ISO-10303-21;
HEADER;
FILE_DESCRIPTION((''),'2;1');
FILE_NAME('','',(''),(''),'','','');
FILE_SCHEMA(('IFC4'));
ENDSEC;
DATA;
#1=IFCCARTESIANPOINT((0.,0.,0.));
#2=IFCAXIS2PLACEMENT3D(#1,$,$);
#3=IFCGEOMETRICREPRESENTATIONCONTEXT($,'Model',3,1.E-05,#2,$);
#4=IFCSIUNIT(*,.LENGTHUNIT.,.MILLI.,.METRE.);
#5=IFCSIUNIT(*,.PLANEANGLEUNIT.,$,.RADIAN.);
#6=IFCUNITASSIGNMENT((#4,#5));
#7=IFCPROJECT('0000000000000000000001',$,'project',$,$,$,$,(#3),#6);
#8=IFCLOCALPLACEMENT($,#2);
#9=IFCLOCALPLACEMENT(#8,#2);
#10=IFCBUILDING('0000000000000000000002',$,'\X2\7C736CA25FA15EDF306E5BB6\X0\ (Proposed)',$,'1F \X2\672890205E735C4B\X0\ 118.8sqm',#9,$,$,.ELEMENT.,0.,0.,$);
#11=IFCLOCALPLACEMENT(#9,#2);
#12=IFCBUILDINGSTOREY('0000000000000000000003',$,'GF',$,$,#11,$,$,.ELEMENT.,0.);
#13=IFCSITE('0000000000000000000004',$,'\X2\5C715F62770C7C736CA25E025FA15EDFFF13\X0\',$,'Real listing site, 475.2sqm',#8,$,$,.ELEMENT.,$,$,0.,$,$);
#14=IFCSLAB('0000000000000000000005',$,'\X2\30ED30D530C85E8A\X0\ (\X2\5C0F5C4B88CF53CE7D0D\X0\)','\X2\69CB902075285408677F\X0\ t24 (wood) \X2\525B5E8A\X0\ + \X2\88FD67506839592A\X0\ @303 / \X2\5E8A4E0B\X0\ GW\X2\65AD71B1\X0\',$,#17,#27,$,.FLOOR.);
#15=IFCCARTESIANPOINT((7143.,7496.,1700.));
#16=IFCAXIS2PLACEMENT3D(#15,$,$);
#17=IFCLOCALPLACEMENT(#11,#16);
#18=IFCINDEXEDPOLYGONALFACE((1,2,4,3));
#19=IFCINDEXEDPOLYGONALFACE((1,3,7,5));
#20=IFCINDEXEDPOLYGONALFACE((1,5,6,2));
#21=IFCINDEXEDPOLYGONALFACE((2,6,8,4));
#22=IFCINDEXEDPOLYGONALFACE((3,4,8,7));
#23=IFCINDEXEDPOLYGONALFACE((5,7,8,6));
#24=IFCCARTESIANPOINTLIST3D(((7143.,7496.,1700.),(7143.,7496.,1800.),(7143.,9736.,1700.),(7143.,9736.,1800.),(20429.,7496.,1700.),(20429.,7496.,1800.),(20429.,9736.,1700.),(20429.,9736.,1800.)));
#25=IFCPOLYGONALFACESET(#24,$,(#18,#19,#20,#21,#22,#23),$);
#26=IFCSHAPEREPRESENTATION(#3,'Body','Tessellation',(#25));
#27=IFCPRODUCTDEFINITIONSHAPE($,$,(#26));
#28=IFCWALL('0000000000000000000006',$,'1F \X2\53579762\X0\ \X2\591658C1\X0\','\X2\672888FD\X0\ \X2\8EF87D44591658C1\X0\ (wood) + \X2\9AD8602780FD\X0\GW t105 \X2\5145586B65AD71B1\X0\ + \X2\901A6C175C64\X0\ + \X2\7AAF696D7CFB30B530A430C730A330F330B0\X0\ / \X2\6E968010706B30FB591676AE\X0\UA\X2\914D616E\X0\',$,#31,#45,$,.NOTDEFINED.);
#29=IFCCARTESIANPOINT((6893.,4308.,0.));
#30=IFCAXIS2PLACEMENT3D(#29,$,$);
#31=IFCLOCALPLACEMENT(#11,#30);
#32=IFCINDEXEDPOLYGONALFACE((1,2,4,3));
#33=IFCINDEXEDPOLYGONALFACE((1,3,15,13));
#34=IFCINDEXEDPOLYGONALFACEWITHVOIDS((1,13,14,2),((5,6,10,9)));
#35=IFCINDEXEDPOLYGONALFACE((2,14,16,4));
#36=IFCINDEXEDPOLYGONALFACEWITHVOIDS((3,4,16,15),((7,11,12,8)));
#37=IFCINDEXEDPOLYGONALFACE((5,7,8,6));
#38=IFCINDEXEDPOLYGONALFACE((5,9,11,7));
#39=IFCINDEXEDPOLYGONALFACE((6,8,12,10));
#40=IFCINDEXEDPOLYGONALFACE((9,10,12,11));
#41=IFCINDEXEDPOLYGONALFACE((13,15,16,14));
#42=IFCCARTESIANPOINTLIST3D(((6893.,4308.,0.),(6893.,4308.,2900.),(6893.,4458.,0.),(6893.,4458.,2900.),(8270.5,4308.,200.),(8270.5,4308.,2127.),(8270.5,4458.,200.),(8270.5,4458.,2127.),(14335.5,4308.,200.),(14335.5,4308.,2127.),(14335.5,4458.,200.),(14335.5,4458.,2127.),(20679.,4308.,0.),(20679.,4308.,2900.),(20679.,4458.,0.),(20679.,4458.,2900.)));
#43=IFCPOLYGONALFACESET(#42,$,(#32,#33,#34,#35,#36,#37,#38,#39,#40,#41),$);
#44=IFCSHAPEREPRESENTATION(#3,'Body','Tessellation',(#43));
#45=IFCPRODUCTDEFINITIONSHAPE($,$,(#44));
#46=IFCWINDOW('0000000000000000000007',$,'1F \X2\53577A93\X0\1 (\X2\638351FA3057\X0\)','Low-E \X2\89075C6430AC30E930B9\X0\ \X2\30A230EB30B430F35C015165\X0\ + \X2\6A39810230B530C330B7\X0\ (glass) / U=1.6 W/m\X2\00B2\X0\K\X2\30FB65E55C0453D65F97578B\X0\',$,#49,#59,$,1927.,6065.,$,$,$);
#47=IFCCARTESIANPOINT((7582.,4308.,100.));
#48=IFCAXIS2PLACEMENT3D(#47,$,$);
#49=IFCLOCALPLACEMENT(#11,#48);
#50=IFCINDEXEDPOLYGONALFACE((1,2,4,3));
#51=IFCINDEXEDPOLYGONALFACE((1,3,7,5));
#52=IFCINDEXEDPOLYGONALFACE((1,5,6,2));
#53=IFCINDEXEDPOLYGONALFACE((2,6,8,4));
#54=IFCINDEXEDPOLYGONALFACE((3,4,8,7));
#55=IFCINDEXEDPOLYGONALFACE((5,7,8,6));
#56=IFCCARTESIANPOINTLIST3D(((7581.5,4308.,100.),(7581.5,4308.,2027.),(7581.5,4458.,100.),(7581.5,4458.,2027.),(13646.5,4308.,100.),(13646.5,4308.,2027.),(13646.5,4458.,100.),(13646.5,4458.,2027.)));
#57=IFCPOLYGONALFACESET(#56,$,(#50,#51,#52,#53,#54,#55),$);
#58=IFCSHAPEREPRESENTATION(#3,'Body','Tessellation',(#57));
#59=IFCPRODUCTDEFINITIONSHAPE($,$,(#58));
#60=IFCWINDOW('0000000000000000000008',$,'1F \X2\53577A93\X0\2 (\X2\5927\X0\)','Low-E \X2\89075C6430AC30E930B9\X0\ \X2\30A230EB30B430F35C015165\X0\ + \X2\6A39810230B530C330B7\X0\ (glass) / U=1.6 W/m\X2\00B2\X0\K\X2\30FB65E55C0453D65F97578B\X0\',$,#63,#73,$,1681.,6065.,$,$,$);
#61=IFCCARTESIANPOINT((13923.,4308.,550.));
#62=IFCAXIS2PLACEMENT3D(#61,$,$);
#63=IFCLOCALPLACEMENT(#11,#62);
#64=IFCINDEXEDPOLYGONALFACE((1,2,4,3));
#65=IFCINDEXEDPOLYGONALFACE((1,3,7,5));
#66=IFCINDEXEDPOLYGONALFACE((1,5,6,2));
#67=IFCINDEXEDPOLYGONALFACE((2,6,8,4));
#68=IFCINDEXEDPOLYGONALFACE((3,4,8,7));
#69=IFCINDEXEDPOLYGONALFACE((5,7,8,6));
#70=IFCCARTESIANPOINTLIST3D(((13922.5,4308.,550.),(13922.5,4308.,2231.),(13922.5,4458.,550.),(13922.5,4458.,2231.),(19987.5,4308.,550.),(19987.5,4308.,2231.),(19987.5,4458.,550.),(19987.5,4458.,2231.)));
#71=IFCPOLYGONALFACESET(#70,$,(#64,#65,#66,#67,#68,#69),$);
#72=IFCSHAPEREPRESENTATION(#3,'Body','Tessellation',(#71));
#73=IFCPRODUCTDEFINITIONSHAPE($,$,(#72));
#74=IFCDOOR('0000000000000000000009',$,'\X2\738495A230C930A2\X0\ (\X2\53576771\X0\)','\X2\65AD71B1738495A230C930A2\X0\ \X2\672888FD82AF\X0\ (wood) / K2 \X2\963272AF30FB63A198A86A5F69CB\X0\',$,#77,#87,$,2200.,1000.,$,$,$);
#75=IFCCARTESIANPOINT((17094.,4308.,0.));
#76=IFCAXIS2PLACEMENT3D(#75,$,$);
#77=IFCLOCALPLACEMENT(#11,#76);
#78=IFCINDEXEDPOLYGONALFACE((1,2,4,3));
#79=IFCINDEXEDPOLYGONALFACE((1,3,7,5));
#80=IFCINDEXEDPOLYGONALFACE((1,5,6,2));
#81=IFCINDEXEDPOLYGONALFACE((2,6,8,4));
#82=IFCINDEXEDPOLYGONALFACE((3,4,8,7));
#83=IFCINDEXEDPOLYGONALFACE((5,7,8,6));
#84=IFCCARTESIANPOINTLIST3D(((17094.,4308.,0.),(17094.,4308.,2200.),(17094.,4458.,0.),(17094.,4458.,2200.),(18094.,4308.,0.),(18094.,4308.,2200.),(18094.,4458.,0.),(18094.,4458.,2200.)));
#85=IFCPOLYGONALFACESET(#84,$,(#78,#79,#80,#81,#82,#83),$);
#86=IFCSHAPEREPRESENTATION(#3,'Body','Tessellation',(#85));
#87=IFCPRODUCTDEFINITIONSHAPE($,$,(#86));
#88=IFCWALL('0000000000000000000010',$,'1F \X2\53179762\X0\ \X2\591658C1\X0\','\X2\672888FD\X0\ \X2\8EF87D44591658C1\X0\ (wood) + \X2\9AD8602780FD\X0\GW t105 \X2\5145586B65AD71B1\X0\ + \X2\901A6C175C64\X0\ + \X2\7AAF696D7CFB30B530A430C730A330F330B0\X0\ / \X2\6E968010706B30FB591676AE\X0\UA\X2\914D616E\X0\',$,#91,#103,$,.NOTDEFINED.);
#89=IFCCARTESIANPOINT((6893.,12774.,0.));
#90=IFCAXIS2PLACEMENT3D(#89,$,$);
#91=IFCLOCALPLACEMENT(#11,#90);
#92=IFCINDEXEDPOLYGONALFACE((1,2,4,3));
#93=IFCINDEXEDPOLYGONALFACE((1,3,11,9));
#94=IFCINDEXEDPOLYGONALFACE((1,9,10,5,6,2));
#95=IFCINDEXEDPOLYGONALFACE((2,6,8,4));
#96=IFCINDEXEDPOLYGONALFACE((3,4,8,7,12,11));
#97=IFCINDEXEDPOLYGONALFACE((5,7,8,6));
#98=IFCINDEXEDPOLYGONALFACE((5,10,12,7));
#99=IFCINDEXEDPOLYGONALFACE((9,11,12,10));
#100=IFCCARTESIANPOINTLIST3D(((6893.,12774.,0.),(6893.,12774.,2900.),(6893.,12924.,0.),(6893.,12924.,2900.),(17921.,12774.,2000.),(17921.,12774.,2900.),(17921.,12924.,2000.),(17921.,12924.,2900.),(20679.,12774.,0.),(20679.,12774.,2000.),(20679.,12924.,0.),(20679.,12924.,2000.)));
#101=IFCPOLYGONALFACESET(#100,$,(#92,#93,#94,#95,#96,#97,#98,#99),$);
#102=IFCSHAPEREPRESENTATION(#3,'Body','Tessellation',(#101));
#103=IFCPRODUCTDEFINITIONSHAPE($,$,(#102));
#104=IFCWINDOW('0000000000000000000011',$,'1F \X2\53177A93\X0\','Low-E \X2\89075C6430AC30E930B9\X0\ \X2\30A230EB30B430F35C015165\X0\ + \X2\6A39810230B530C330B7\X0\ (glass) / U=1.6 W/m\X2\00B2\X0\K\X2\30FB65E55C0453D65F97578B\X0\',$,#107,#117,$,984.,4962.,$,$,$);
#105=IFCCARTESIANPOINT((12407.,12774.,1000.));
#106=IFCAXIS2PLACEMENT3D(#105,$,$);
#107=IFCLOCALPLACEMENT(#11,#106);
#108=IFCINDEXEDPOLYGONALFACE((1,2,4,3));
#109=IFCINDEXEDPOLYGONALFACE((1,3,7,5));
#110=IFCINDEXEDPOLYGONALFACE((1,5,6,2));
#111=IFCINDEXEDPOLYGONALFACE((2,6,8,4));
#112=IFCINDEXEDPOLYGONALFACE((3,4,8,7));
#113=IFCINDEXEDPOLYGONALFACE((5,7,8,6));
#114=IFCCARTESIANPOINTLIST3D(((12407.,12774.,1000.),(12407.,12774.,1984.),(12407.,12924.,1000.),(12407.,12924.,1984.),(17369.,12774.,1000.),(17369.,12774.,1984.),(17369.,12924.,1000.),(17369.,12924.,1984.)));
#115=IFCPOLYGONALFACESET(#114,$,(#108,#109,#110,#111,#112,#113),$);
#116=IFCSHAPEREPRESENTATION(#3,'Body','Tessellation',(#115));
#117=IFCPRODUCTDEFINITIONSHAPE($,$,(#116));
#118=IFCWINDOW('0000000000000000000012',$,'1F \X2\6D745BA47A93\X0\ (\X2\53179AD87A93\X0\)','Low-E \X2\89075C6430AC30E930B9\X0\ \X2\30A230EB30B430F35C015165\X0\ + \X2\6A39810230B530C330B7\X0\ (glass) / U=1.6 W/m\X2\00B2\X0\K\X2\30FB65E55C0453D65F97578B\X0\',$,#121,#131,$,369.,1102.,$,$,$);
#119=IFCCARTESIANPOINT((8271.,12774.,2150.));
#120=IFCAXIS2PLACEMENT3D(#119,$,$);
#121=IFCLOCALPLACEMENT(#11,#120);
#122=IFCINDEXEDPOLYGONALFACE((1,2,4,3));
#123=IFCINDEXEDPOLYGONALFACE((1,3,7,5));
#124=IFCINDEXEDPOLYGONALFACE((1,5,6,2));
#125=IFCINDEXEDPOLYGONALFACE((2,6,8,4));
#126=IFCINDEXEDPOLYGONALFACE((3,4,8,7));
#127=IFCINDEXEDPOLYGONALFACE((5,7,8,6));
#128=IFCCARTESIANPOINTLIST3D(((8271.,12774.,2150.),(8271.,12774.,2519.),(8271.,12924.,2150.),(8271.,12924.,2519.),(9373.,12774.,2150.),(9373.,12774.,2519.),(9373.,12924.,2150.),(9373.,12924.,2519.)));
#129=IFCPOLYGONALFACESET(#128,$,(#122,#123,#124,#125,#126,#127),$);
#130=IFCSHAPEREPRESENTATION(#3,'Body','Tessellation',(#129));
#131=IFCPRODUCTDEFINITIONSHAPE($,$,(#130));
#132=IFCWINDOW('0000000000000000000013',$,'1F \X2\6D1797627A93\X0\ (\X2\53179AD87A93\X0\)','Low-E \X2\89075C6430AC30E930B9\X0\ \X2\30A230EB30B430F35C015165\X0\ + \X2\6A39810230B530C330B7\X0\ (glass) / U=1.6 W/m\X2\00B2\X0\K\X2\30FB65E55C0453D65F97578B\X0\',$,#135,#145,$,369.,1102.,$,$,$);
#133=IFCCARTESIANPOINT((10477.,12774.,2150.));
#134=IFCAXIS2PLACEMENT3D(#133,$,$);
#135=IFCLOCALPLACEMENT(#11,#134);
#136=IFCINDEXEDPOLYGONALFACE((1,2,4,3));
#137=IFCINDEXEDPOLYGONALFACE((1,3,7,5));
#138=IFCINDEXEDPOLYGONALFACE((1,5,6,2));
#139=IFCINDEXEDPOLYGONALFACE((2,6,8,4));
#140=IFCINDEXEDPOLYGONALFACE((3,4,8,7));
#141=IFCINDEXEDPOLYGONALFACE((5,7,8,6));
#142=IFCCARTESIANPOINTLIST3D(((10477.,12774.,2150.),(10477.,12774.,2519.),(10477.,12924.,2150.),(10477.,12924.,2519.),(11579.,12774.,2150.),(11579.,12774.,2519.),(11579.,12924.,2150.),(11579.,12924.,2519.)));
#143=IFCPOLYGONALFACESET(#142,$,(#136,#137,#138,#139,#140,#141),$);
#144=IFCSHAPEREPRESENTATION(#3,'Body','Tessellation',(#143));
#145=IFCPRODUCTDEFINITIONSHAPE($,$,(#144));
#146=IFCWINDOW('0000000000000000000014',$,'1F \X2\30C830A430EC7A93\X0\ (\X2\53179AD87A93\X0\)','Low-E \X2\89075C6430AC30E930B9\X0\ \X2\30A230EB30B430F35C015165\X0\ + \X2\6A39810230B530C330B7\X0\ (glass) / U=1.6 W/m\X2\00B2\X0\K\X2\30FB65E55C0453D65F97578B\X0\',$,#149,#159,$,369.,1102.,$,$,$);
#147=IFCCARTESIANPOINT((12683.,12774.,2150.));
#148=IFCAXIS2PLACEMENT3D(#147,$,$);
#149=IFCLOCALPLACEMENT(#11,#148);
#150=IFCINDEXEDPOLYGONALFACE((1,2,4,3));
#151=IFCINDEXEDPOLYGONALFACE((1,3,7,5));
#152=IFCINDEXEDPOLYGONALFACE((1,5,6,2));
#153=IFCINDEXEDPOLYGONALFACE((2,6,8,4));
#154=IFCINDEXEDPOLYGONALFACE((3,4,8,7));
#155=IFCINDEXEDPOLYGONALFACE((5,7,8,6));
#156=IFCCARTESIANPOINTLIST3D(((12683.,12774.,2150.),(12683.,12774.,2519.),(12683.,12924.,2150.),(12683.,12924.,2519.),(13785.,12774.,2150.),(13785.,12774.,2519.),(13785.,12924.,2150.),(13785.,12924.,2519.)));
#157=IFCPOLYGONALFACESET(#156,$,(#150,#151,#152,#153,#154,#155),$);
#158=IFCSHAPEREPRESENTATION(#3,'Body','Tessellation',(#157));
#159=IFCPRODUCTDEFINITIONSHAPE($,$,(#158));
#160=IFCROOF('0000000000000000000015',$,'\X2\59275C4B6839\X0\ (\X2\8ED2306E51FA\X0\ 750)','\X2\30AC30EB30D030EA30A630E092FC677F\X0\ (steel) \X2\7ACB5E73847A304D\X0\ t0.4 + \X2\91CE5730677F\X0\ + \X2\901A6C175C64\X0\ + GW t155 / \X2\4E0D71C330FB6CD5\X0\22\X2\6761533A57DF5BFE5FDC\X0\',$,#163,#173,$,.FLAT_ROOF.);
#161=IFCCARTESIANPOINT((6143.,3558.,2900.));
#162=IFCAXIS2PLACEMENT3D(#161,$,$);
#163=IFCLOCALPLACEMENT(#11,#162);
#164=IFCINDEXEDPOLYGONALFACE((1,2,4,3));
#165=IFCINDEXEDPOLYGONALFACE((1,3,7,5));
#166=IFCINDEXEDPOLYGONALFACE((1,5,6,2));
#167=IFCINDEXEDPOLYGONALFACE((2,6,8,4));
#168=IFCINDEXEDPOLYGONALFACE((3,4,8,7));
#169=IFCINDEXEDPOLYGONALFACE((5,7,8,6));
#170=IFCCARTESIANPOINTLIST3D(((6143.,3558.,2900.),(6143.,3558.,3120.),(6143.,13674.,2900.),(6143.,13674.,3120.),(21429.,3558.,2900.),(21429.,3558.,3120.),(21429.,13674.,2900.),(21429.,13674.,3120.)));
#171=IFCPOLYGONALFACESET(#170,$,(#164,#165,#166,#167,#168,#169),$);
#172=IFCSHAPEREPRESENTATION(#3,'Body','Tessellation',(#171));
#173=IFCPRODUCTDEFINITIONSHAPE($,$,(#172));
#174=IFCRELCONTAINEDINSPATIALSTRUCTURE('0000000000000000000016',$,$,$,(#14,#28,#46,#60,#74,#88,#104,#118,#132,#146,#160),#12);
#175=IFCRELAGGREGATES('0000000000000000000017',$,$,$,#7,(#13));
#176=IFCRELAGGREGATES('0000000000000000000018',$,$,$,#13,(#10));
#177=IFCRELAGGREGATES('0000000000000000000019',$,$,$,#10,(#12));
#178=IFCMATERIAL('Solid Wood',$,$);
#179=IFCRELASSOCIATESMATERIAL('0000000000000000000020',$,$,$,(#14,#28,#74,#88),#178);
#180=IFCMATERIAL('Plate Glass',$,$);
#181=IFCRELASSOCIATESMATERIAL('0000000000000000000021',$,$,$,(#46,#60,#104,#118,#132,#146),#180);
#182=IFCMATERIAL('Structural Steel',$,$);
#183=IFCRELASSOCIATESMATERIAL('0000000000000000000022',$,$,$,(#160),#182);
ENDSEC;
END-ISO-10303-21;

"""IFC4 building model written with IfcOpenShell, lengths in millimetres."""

from ifc_helpers import new_model, si_unit, frame, frame_2d, origin, place, context, project, spatial, rectangle, extrude, material, element, fill, save


model = new_model("IFC4")

# Units and contexts
model_context = context("Model", 3, precision=1e-05, world=origin())
ifc_project = project(units=[si_unit("LENGTHUNIT", "METRE", prefix="MILLI"), si_unit("PLANEANGLEUNIT", "RADIAN")], contexts=[model_context])

# Site, building, storey
site_placement = place(None, origin())
site = spatial("IfcSite", under=ifc_project, at=site_placement, Name="山形県米沢市御廟３", ObjectType="Real listing site, 475.2sqm", CompositionType="ELEMENT", RefElevation=0.0)
building_placement = place(site_placement, origin())
building = spatial("IfcBuilding", under=site, at=building_placement, Name="米沢御廟の家 (Proposed)", ObjectType="1F 木造平屋 118.8sqm", CompositionType="ELEMENT", ElevationOfRefHeight=0.0, ElevationOfTerrain=0.0)
storey_placement = place(building_placement, origin())
storey = spatial("IfcBuildingStorey", under=building, at=storey_placement, Name="GF", CompositionType="ELEMENT", Elevation=0.0)

# Slab
ifc_material_1 = material(Name="Solid Wood")
slab_1_placement = place(storey_placement, frame((7143.0, 7496.0, 1700.0)))
element("IfcSlab", 1, at=slab_1_placement, inside=storey, material=ifc_material_1, Name="ロフト床 (小屋裏収納)", Description="構造用合板 t24 (wood) 剛床 + 製材根太 @303 / 床下 GW断熱", PredefinedType="FLOOR", context=model_context, shape_type="SweptSolid", body=[
    extrude(rectangle(XDim=13286.0, YDim=2240.0, at=frame_2d((6643.0, 1120.0))), frame((7143.0, 7496.0, 1700.0)), (0.0, 0.0, 1.0), 100.0),
])

# Wall, openings, windows, door
wall_1_placement = place(storey_placement, frame((6893.0, 4308.0, 0.0)))
wall_1 = element("IfcWall", 2, at=wall_1_placement, inside=storey, material=ifc_material_1, Name="1F 南面 外壁", Description="木製 軸組外壁 (wood) + 高性能GW t105 充填断熱 + 通気層 + 窯業系サイディング / 準耐火・外皮UA配慮", PredefinedType="NOTDEFINED", context=model_context, shape_type="SweptSolid", body=[
    extrude(rectangle(XDim=13786.0, YDim=150.0, at=frame_2d((6893.0, 75.0))), frame((6893.0, 4308.0, 0.0)), (0.0, 0.0, 1.0), 2900.0),
])
opening_1_placement = place(storey_placement, frame((7582.0, 4308.0, 100.0)))
opening_1 = element("IfcOpeningElement", 3, at=opening_1_placement, cuts=wall_1, PredefinedType="NOTDEFINED", context=model_context, shape_type="SweptSolid", body=[
    extrude(rectangle(XDim=6065.0, YDim=150.0, at=frame_2d((3032.0, 75.0))), frame((7582.0, 4308.0, 100.0)), (0.0, 0.0, 1.0), 1927.0),
])
opening_2_placement = place(storey_placement, frame((13923.0, 4308.0, 550.0)))
opening_2 = element("IfcOpeningElement", 4, at=opening_2_placement, cuts=wall_1, PredefinedType="NOTDEFINED", context=model_context, shape_type="SweptSolid", body=[
    extrude(rectangle(XDim=6065.0, YDim=150.0, at=frame_2d((3032.0, 75.0))), frame((13923.0, 4308.0, 550.0)), (0.0, 0.0, 1.0), 1681.0),
])
opening_3_placement = place(storey_placement, frame((17094.0, 4308.0, 0.0)))
opening_3 = element("IfcOpeningElement", 5, at=opening_3_placement, cuts=wall_1, PredefinedType="NOTDEFINED", context=model_context, shape_type="SweptSolid", body=[
    extrude(rectangle(XDim=1000.0, YDim=150.0, at=frame_2d((500.0, 75.0))), frame((17094.0, 4308.0, 0.0)), (0.0, 0.0, 1.0), 2200.0),
])
ifc_material_2 = material(Name="Plate Glass")
window_1_placement = place(storey_placement, frame((7582.0, 4308.0, 100.0)))
window_1 = element("IfcWindow", 6, at=window_1_placement, inside=storey, material=ifc_material_2, Name="1F 南窓1 (掃出し)", Description="Low-E 複層ガラス アルゴン封入 + 樹脂サッシ (glass) / U=1.6 W/m²K・日射取得型", OverallHeight=1927.0, OverallWidth=6065.0, context=model_context, shape_type="SweptSolid", body=[
    extrude(rectangle(XDim=6065.0, YDim=150.0, at=frame_2d((3032.0, 75.0))), frame((7582.0, 4308.0, 100.0)), (0.0, 0.0, 1.0), 1927.0),
])
fill(opening_1, window_1)
window_2_placement = place(storey_placement, frame((13923.0, 4308.0, 550.0)))
window_2 = element("IfcWindow", 7, at=window_2_placement, inside=storey, material=ifc_material_2, Name="1F 南窓2 (大)", Description="Low-E 複層ガラス アルゴン封入 + 樹脂サッシ (glass) / U=1.6 W/m²K・日射取得型", OverallHeight=1681.0, OverallWidth=6065.0, context=model_context, shape_type="SweptSolid", body=[
    extrude(rectangle(XDim=6065.0, YDim=150.0, at=frame_2d((3032.0, 75.0))), frame((13923.0, 4308.0, 550.0)), (0.0, 0.0, 1.0), 1681.0),
])
fill(opening_2, window_2)
door_1_placement = place(storey_placement, frame((17094.0, 4308.0, 0.0)))
door_1 = element("IfcDoor", 8, at=door_1_placement, inside=storey, material=ifc_material_1, Name="玄関ドア (南東)", Description="断熱玄関ドア 木製芯 (wood) / K2 防犯・採風機構", OverallHeight=2200.0, OverallWidth=1000.0, context=model_context, shape_type="SweptSolid", body=[
    extrude(rectangle(XDim=1000.0, YDim=150.0, at=frame_2d((500.0, 75.0))), frame((17094.0, 4308.0, 0.0)), (0.0, 0.0, 1.0), 2200.0),
])
fill(opening_3, door_1)

# Wall, openings, windows
wall_2_placement = place(storey_placement, frame((6893.0, 12774.0, 0.0)))
wall_2 = element("IfcWall", 9, at=wall_2_placement, inside=storey, material=ifc_material_1, Name="1F 北面 外壁", Description="木製 軸組外壁 (wood) + 高性能GW t105 充填断熱 + 通気層 + 窯業系サイディング / 準耐火・外皮UA配慮", PredefinedType="NOTDEFINED", context=model_context, shape_type="SweptSolid", body=[
    extrude(rectangle(XDim=13786.0, YDim=150.0, at=frame_2d((6893.0, 75.0))), frame((6893.0, 12774.0, 0.0)), (0.0, 0.0, 1.0), 2900.0),
])
opening_4_placement = place(storey_placement, frame((12407.0, 12774.0, 1000.0)))
opening_4 = element("IfcOpeningElement", 10, at=opening_4_placement, cuts=wall_2, PredefinedType="NOTDEFINED", context=model_context, shape_type="SweptSolid", body=[
    extrude(rectangle(XDim=4962.0, YDim=150.0, at=frame_2d((2481.0, 75.0))), frame((12407.0, 12774.0, 1000.0)), (0.0, 0.0, 1.0), 984.0),
])
opening_5_placement = place(storey_placement, frame((8271.0, 12774.0, 2150.0)))
opening_5 = element("IfcOpeningElement", 11, at=opening_5_placement, cuts=wall_2, PredefinedType="NOTDEFINED", context=model_context, shape_type="SweptSolid", body=[
    extrude(rectangle(XDim=1102.0, YDim=150.0, at=frame_2d((551.0, 75.0))), frame((8271.0, 12774.0, 2150.0)), (0.0, 0.0, 1.0), 369.0),
])
opening_6_placement = place(storey_placement, frame((10477.0, 12774.0, 2150.0)))
opening_6 = element("IfcOpeningElement", 12, at=opening_6_placement, cuts=wall_2, PredefinedType="NOTDEFINED", context=model_context, shape_type="SweptSolid", body=[
    extrude(rectangle(XDim=1102.0, YDim=150.0, at=frame_2d((551.0, 75.0))), frame((10477.0, 12774.0, 2150.0)), (0.0, 0.0, 1.0), 369.0),
])
opening_7_placement = place(storey_placement, frame((12683.0, 12774.0, 2150.0)))
opening_7 = element("IfcOpeningElement", 13, at=opening_7_placement, cuts=wall_2, PredefinedType="NOTDEFINED", context=model_context, shape_type="SweptSolid", body=[
    extrude(rectangle(XDim=1102.0, YDim=150.0, at=frame_2d((551.0, 75.0))), frame((12683.0, 12774.0, 2150.0)), (0.0, 0.0, 1.0), 369.0),
])
window_3_placement = place(storey_placement, frame((12407.0, 12774.0, 1000.0)))
window_3 = element("IfcWindow", 14, at=window_3_placement, inside=storey, material=ifc_material_2, Name="1F 北窓", Description="Low-E 複層ガラス アルゴン封入 + 樹脂サッシ (glass) / U=1.6 W/m²K・日射取得型", OverallHeight=984.0, OverallWidth=4962.0, context=model_context, shape_type="SweptSolid", body=[
    extrude(rectangle(XDim=4962.0, YDim=150.0, at=frame_2d((2481.0, 75.0))), frame((12407.0, 12774.0, 1000.0)), (0.0, 0.0, 1.0), 984.0),
])
fill(opening_4, window_3)
window_4_placement = place(storey_placement, frame((8271.0, 12774.0, 2150.0)))
window_4 = element("IfcWindow", 15, at=window_4_placement, inside=storey, material=ifc_material_2, Name="1F 浴室窓 (北高窓)", Description="Low-E 複層ガラス アルゴン封入 + 樹脂サッシ (glass) / U=1.6 W/m²K・日射取得型", OverallHeight=369.0, OverallWidth=1102.0, context=model_context, shape_type="SweptSolid", body=[
    extrude(rectangle(XDim=1102.0, YDim=150.0, at=frame_2d((551.0, 75.0))), frame((8271.0, 12774.0, 2150.0)), (0.0, 0.0, 1.0), 369.0),
])
fill(opening_5, window_4)
window_5_placement = place(storey_placement, frame((10477.0, 12774.0, 2150.0)))
window_5 = element("IfcWindow", 16, at=window_5_placement, inside=storey, material=ifc_material_2, Name="1F 洗面窓 (北高窓)", Description="Low-E 複層ガラス アルゴン封入 + 樹脂サッシ (glass) / U=1.6 W/m²K・日射取得型", OverallHeight=369.0, OverallWidth=1102.0, context=model_context, shape_type="SweptSolid", body=[
    extrude(rectangle(XDim=1102.0, YDim=150.0, at=frame_2d((551.0, 75.0))), frame((10477.0, 12774.0, 2150.0)), (0.0, 0.0, 1.0), 369.0),
])
fill(opening_6, window_5)
window_6_placement = place(storey_placement, frame((12683.0, 12774.0, 2150.0)))
window_6 = element("IfcWindow", 17, at=window_6_placement, inside=storey, material=ifc_material_2, Name="1F トイレ窓 (北高窓)", Description="Low-E 複層ガラス アルゴン封入 + 樹脂サッシ (glass) / U=1.6 W/m²K・日射取得型", OverallHeight=369.0, OverallWidth=1102.0, context=model_context, shape_type="SweptSolid", body=[
    extrude(rectangle(XDim=1102.0, YDim=150.0, at=frame_2d((551.0, 75.0))), frame((12683.0, 12774.0, 2150.0)), (0.0, 0.0, 1.0), 369.0),
])
fill(opening_7, window_6)

# Roof
ifc_material_3 = material(Name="Structural Steel")
roof_placement = place(storey_placement, frame((6143.0, 3558.0, 2900.0)))
element("IfcRoof", 18, at=roof_placement, inside=storey, material=ifc_material_3, Name="大屋根 (軒の出 750)", Description="ガルバリウム鋼板 (steel) 立平葺き t0.4 + 野地板 + 通気層 + GW t155 / 不燃・法22条区域対応", PredefinedType="FLAT_ROOF", context=model_context, shape_type="SweptSolid", body=[
    extrude(rectangle(XDim=15286.0, YDim=10116.0, at=frame_2d((7643.0, 5058.0))), frame((6143.0, 3558.0, 2900.0)), (0.0, 0.0, 1.0), 220.0),
])

save(model, "model.ifc")
